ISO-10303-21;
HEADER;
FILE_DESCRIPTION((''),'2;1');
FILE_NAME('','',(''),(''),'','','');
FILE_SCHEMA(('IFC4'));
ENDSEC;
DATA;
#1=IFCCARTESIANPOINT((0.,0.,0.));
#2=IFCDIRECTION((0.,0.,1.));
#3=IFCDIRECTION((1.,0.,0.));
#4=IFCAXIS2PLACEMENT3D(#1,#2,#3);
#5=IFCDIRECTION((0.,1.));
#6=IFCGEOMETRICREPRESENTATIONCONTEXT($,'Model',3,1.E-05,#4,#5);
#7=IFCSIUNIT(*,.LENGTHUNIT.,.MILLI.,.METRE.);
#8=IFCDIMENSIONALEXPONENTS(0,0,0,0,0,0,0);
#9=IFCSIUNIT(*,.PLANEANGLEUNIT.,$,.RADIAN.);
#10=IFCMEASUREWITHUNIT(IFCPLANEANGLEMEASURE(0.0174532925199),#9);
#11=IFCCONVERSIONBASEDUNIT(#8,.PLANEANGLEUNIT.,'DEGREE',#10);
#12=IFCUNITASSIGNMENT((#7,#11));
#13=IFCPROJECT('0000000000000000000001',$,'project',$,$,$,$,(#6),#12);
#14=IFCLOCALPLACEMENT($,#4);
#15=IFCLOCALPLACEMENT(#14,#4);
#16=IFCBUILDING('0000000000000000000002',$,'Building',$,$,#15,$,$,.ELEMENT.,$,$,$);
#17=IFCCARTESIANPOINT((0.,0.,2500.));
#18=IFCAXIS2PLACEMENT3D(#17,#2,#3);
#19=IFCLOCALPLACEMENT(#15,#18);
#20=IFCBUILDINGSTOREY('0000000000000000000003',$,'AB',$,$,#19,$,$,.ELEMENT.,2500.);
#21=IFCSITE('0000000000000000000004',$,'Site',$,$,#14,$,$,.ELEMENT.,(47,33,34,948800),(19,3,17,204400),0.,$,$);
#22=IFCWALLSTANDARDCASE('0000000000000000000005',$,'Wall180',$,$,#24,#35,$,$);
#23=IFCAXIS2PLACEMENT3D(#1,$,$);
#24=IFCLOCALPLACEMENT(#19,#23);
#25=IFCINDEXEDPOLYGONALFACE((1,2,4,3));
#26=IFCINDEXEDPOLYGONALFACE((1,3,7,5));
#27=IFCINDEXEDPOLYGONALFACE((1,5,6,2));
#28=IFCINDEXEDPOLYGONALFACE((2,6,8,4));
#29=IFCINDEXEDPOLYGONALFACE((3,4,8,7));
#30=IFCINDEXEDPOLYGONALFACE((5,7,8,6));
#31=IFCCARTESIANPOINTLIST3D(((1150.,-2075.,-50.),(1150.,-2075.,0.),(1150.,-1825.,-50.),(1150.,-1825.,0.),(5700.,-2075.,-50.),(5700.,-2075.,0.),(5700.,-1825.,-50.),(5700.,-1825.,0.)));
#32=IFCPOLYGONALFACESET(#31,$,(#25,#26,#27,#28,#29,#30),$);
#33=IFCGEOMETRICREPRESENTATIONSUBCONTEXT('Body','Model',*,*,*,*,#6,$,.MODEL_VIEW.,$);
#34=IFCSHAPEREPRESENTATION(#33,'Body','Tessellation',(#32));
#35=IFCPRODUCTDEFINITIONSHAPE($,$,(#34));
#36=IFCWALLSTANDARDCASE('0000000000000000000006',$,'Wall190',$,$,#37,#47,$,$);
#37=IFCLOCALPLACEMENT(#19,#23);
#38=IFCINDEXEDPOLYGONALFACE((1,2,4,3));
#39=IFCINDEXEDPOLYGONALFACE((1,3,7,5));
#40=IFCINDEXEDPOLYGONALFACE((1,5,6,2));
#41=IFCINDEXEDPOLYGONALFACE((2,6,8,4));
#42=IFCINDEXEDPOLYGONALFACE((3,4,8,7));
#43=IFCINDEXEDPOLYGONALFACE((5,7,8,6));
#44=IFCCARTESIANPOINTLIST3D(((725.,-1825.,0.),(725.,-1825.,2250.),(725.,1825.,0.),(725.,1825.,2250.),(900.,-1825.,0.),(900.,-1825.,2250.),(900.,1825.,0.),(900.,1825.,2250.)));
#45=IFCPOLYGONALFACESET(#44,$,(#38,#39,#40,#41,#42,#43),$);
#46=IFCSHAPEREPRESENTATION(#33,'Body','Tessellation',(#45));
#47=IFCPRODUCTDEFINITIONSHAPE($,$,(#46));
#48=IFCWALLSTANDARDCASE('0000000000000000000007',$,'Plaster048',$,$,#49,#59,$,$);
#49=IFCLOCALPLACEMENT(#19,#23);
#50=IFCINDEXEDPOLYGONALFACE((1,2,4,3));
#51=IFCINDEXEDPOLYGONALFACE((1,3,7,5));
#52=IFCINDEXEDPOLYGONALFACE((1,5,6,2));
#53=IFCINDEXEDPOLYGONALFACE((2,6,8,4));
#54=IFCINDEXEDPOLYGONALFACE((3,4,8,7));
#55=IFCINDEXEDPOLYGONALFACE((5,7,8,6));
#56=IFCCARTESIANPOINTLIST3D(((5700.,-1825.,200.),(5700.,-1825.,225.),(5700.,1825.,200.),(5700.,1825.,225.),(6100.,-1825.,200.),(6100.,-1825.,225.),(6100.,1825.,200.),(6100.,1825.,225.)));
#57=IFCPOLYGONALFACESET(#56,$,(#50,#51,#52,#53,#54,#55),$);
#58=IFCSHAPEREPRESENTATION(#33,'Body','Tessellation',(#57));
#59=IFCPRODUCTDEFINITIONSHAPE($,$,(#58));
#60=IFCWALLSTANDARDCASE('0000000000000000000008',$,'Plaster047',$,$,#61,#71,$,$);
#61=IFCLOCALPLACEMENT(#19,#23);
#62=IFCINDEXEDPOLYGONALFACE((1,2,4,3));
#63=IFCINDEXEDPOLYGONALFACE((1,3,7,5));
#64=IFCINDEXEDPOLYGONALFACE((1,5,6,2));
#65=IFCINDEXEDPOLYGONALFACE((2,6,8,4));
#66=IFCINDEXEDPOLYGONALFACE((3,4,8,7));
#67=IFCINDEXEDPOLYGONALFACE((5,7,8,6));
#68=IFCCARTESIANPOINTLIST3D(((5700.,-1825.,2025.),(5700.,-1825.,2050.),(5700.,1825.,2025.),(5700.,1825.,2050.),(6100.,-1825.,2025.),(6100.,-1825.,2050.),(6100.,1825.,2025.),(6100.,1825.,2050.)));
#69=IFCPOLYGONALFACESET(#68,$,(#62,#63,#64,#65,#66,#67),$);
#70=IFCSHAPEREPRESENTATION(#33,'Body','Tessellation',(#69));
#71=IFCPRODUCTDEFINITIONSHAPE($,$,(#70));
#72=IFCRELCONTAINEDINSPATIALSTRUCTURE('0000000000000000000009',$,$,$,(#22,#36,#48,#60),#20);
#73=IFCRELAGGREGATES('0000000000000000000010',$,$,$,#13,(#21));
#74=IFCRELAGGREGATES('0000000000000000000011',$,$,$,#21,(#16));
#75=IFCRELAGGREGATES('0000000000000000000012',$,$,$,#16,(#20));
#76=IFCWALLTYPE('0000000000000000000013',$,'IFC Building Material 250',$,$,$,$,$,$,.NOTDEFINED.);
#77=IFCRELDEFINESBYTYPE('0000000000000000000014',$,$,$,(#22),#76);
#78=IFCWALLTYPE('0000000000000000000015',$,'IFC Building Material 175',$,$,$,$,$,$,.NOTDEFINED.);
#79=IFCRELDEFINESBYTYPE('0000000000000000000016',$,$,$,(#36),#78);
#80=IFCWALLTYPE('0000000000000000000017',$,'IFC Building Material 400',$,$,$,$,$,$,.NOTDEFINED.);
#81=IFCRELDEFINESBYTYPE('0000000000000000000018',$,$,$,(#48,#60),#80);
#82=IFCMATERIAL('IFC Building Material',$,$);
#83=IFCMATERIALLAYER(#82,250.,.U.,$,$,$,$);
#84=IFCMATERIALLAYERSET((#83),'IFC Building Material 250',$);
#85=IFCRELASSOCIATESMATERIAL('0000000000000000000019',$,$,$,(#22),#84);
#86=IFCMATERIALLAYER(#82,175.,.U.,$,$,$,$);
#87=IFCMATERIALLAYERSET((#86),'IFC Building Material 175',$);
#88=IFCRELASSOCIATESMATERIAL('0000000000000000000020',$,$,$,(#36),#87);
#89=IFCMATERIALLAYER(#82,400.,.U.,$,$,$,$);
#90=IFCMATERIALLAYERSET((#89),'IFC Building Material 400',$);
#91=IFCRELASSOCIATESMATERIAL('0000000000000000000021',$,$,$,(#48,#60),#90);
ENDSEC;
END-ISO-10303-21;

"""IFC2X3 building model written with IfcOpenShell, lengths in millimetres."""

from ifc_helpers import new_model, entity, si_unit, converted_unit, direction, frame, origin_with_axes, place, context, subcontext, project, spatial, polyline, outline, extrude, material, layer, layer_set, layer_usage, type_object, element, save


model = new_model("IFC2X3")

# Units and contexts
model_context = context("Model", 3, precision=1e-05, world=origin_with_axes(), true_north=direction((0.0, 1.0)))
body_context = subcontext(model_context, "Body", "Model", "MODEL_VIEW")
ifc_project = project(units=[si_unit("LENGTHUNIT", "METRE", prefix="MILLI"), converted_unit("PLANEANGLEUNIT", "DEGREE", entity("IfcPlaneAngleMeasure", 0.0174532925199), si_unit("PLANEANGLEUNIT", "RADIAN"), dimensions=[0, 0, 0, 0, 0, 0, 0])], contexts=[model_context])

# Site, building, storey
site_placement = place(None, origin_with_axes())
site = spatial("IfcSite", under=ifc_project, at=site_placement, Name="Site", CompositionType="ELEMENT", RefLatitude=(47, 33, 34, 948800), RefLongitude=(19, 3, 17, 204400), RefElevation=0.0)
building_placement = place(site_placement, origin_with_axes())
building = spatial("IfcBuilding", under=site, at=building_placement, Name="Building", CompositionType="ELEMENT")
storey_placement = place(building_placement, frame((0.0, 0.0, 2500.0), z_axis=(0.0, 0.0, 1.0), x_axis=(1.0, 0.0, 0.0)))
storey = spatial("IfcBuildingStorey", under=building, at=storey_placement, Name="AB", CompositionType="ELEMENT", Elevation=2500.0)

# Shared definitions
ifc_material = material(Name="IFC Building Material")

# Walls
ifc_layer_1 = layer(ifc_material, 250.0, ventilated="UNKNOWN")
ifc_layer_set_1 = layer_set([ifc_layer_1], Name="IFC Building Material 250")
wall_type_1 = type_object("IfcWallType", Name="IFC Building Material 250", PredefinedType="NOTDEFINED")
ifc_layer_usage_1 = layer_usage(ifc_layer_set_1, "AXIS2", "POSITIVE", 0.0)
wall_1_placement = place(storey_placement, frame((1150.0, -2075.0, -50.0), z_axis=(0.0, 0.0, 1.0), x_axis=(1.0, 0.0, 0.0)))
element("IfcWallStandardCase", 1, at=wall_1_placement, inside=storey, type_object=wall_type_1, material=ifc_layer_usage_1, Name="Wall180", context=body_context, shape_type="SweptSolid", body=[
    extrude(outline(polyline([(0.0, 0.0), (4550.0, 0.0), (4550.0, 250.0), (0.0, 250.0), (0.0, 0.0)])), origin_with_axes(), (0.0, 0.0, 1.0), 50.0),
])
ifc_layer_2 = layer(ifc_material, 175.0, ventilated="UNKNOWN")
ifc_layer_set_2 = layer_set([ifc_layer_2], Name="IFC Building Material 175")
ifc_layer_usage_2 = layer_usage(ifc_layer_set_2, "AXIS2", "POSITIVE", -175.0)
wall_type_2 = type_object("IfcWallType", Name="IFC Building Material 175", PredefinedType="NOTDEFINED")
wall_2_placement = place(storey_placement, frame((900.0, 1825.0, 0.0), z_axis=(0.0, 0.0, 1.0), x_axis=(0.0, -1.0, 0.0)))
element("IfcWallStandardCase", 2, at=wall_2_placement, inside=storey, type_object=wall_type_2, material=ifc_layer_usage_2, Name="Wall190", context=body_context, shape_type="SweptSolid", body=[
    extrude(outline(polyline([(0.0, -175.0), (3650.0, -175.0), (3650.0, 0.0), (0.0, 0.0), (0.0, -175.0)])), origin_with_axes(), (0.0, 0.0, 1.0), 2250.0),
])
ifc_layer_3 = layer(ifc_material, 400.0, ventilated="UNKNOWN")
ifc_layer_set_3 = layer_set([ifc_layer_3], Name="IFC Building Material 400")
ifc_layer_usage_3 = layer_usage(ifc_layer_set_3, "AXIS2", "NEGATIVE", 400.0)
wall_type_3 = type_object("IfcWallType", Name="IFC Building Material 400", PredefinedType="NOTDEFINED")
wall_3_placement = place(storey_placement, frame((6100.0, -1825.0, 200.0), z_axis=(0.0, 0.0, 1.0), x_axis=(0.0, 1.0, 0.0)))
element("IfcWallStandardCase", 3, at=wall_3_placement, inside=storey, type_object=wall_type_3, material=ifc_layer_usage_3, Name="Plaster048", context=body_context, shape_type="SweptSolid", body=[
    extrude(outline(polyline([(0.0, 0.0), (3650.0, 0.0), (3650.0, 400.0), (0.0, 400.0), (0.0, 0.0)])), origin_with_axes(), (0.0, 0.0, 1.0), 25.0),
])
ifc_layer_usage_4 = layer_usage(ifc_layer_set_3, "AXIS2", "POSITIVE", -400.0)
wall_4_placement = place(storey_placement, frame((5700.0, -1825.0, 2025.0), z_axis=(0.0, 0.0, 1.0), x_axis=(0.0, 1.0, 0.0)))
element("IfcWallStandardCase", 4, at=wall_4_placement, inside=storey, type_object=wall_type_3, material=ifc_layer_usage_4, Name="Plaster047", context=body_context, shape_type="SweptSolid", body=[
    extrude(outline(polyline([(0.0, -400.0), (3650.0, -400.0), (3650.0, 0.0), (0.0, 0.0), (0.0, -400.0)])), origin_with_axes(), (0.0, 0.0, 1.0), 25.0),
])

save(model, "model.ifc")
